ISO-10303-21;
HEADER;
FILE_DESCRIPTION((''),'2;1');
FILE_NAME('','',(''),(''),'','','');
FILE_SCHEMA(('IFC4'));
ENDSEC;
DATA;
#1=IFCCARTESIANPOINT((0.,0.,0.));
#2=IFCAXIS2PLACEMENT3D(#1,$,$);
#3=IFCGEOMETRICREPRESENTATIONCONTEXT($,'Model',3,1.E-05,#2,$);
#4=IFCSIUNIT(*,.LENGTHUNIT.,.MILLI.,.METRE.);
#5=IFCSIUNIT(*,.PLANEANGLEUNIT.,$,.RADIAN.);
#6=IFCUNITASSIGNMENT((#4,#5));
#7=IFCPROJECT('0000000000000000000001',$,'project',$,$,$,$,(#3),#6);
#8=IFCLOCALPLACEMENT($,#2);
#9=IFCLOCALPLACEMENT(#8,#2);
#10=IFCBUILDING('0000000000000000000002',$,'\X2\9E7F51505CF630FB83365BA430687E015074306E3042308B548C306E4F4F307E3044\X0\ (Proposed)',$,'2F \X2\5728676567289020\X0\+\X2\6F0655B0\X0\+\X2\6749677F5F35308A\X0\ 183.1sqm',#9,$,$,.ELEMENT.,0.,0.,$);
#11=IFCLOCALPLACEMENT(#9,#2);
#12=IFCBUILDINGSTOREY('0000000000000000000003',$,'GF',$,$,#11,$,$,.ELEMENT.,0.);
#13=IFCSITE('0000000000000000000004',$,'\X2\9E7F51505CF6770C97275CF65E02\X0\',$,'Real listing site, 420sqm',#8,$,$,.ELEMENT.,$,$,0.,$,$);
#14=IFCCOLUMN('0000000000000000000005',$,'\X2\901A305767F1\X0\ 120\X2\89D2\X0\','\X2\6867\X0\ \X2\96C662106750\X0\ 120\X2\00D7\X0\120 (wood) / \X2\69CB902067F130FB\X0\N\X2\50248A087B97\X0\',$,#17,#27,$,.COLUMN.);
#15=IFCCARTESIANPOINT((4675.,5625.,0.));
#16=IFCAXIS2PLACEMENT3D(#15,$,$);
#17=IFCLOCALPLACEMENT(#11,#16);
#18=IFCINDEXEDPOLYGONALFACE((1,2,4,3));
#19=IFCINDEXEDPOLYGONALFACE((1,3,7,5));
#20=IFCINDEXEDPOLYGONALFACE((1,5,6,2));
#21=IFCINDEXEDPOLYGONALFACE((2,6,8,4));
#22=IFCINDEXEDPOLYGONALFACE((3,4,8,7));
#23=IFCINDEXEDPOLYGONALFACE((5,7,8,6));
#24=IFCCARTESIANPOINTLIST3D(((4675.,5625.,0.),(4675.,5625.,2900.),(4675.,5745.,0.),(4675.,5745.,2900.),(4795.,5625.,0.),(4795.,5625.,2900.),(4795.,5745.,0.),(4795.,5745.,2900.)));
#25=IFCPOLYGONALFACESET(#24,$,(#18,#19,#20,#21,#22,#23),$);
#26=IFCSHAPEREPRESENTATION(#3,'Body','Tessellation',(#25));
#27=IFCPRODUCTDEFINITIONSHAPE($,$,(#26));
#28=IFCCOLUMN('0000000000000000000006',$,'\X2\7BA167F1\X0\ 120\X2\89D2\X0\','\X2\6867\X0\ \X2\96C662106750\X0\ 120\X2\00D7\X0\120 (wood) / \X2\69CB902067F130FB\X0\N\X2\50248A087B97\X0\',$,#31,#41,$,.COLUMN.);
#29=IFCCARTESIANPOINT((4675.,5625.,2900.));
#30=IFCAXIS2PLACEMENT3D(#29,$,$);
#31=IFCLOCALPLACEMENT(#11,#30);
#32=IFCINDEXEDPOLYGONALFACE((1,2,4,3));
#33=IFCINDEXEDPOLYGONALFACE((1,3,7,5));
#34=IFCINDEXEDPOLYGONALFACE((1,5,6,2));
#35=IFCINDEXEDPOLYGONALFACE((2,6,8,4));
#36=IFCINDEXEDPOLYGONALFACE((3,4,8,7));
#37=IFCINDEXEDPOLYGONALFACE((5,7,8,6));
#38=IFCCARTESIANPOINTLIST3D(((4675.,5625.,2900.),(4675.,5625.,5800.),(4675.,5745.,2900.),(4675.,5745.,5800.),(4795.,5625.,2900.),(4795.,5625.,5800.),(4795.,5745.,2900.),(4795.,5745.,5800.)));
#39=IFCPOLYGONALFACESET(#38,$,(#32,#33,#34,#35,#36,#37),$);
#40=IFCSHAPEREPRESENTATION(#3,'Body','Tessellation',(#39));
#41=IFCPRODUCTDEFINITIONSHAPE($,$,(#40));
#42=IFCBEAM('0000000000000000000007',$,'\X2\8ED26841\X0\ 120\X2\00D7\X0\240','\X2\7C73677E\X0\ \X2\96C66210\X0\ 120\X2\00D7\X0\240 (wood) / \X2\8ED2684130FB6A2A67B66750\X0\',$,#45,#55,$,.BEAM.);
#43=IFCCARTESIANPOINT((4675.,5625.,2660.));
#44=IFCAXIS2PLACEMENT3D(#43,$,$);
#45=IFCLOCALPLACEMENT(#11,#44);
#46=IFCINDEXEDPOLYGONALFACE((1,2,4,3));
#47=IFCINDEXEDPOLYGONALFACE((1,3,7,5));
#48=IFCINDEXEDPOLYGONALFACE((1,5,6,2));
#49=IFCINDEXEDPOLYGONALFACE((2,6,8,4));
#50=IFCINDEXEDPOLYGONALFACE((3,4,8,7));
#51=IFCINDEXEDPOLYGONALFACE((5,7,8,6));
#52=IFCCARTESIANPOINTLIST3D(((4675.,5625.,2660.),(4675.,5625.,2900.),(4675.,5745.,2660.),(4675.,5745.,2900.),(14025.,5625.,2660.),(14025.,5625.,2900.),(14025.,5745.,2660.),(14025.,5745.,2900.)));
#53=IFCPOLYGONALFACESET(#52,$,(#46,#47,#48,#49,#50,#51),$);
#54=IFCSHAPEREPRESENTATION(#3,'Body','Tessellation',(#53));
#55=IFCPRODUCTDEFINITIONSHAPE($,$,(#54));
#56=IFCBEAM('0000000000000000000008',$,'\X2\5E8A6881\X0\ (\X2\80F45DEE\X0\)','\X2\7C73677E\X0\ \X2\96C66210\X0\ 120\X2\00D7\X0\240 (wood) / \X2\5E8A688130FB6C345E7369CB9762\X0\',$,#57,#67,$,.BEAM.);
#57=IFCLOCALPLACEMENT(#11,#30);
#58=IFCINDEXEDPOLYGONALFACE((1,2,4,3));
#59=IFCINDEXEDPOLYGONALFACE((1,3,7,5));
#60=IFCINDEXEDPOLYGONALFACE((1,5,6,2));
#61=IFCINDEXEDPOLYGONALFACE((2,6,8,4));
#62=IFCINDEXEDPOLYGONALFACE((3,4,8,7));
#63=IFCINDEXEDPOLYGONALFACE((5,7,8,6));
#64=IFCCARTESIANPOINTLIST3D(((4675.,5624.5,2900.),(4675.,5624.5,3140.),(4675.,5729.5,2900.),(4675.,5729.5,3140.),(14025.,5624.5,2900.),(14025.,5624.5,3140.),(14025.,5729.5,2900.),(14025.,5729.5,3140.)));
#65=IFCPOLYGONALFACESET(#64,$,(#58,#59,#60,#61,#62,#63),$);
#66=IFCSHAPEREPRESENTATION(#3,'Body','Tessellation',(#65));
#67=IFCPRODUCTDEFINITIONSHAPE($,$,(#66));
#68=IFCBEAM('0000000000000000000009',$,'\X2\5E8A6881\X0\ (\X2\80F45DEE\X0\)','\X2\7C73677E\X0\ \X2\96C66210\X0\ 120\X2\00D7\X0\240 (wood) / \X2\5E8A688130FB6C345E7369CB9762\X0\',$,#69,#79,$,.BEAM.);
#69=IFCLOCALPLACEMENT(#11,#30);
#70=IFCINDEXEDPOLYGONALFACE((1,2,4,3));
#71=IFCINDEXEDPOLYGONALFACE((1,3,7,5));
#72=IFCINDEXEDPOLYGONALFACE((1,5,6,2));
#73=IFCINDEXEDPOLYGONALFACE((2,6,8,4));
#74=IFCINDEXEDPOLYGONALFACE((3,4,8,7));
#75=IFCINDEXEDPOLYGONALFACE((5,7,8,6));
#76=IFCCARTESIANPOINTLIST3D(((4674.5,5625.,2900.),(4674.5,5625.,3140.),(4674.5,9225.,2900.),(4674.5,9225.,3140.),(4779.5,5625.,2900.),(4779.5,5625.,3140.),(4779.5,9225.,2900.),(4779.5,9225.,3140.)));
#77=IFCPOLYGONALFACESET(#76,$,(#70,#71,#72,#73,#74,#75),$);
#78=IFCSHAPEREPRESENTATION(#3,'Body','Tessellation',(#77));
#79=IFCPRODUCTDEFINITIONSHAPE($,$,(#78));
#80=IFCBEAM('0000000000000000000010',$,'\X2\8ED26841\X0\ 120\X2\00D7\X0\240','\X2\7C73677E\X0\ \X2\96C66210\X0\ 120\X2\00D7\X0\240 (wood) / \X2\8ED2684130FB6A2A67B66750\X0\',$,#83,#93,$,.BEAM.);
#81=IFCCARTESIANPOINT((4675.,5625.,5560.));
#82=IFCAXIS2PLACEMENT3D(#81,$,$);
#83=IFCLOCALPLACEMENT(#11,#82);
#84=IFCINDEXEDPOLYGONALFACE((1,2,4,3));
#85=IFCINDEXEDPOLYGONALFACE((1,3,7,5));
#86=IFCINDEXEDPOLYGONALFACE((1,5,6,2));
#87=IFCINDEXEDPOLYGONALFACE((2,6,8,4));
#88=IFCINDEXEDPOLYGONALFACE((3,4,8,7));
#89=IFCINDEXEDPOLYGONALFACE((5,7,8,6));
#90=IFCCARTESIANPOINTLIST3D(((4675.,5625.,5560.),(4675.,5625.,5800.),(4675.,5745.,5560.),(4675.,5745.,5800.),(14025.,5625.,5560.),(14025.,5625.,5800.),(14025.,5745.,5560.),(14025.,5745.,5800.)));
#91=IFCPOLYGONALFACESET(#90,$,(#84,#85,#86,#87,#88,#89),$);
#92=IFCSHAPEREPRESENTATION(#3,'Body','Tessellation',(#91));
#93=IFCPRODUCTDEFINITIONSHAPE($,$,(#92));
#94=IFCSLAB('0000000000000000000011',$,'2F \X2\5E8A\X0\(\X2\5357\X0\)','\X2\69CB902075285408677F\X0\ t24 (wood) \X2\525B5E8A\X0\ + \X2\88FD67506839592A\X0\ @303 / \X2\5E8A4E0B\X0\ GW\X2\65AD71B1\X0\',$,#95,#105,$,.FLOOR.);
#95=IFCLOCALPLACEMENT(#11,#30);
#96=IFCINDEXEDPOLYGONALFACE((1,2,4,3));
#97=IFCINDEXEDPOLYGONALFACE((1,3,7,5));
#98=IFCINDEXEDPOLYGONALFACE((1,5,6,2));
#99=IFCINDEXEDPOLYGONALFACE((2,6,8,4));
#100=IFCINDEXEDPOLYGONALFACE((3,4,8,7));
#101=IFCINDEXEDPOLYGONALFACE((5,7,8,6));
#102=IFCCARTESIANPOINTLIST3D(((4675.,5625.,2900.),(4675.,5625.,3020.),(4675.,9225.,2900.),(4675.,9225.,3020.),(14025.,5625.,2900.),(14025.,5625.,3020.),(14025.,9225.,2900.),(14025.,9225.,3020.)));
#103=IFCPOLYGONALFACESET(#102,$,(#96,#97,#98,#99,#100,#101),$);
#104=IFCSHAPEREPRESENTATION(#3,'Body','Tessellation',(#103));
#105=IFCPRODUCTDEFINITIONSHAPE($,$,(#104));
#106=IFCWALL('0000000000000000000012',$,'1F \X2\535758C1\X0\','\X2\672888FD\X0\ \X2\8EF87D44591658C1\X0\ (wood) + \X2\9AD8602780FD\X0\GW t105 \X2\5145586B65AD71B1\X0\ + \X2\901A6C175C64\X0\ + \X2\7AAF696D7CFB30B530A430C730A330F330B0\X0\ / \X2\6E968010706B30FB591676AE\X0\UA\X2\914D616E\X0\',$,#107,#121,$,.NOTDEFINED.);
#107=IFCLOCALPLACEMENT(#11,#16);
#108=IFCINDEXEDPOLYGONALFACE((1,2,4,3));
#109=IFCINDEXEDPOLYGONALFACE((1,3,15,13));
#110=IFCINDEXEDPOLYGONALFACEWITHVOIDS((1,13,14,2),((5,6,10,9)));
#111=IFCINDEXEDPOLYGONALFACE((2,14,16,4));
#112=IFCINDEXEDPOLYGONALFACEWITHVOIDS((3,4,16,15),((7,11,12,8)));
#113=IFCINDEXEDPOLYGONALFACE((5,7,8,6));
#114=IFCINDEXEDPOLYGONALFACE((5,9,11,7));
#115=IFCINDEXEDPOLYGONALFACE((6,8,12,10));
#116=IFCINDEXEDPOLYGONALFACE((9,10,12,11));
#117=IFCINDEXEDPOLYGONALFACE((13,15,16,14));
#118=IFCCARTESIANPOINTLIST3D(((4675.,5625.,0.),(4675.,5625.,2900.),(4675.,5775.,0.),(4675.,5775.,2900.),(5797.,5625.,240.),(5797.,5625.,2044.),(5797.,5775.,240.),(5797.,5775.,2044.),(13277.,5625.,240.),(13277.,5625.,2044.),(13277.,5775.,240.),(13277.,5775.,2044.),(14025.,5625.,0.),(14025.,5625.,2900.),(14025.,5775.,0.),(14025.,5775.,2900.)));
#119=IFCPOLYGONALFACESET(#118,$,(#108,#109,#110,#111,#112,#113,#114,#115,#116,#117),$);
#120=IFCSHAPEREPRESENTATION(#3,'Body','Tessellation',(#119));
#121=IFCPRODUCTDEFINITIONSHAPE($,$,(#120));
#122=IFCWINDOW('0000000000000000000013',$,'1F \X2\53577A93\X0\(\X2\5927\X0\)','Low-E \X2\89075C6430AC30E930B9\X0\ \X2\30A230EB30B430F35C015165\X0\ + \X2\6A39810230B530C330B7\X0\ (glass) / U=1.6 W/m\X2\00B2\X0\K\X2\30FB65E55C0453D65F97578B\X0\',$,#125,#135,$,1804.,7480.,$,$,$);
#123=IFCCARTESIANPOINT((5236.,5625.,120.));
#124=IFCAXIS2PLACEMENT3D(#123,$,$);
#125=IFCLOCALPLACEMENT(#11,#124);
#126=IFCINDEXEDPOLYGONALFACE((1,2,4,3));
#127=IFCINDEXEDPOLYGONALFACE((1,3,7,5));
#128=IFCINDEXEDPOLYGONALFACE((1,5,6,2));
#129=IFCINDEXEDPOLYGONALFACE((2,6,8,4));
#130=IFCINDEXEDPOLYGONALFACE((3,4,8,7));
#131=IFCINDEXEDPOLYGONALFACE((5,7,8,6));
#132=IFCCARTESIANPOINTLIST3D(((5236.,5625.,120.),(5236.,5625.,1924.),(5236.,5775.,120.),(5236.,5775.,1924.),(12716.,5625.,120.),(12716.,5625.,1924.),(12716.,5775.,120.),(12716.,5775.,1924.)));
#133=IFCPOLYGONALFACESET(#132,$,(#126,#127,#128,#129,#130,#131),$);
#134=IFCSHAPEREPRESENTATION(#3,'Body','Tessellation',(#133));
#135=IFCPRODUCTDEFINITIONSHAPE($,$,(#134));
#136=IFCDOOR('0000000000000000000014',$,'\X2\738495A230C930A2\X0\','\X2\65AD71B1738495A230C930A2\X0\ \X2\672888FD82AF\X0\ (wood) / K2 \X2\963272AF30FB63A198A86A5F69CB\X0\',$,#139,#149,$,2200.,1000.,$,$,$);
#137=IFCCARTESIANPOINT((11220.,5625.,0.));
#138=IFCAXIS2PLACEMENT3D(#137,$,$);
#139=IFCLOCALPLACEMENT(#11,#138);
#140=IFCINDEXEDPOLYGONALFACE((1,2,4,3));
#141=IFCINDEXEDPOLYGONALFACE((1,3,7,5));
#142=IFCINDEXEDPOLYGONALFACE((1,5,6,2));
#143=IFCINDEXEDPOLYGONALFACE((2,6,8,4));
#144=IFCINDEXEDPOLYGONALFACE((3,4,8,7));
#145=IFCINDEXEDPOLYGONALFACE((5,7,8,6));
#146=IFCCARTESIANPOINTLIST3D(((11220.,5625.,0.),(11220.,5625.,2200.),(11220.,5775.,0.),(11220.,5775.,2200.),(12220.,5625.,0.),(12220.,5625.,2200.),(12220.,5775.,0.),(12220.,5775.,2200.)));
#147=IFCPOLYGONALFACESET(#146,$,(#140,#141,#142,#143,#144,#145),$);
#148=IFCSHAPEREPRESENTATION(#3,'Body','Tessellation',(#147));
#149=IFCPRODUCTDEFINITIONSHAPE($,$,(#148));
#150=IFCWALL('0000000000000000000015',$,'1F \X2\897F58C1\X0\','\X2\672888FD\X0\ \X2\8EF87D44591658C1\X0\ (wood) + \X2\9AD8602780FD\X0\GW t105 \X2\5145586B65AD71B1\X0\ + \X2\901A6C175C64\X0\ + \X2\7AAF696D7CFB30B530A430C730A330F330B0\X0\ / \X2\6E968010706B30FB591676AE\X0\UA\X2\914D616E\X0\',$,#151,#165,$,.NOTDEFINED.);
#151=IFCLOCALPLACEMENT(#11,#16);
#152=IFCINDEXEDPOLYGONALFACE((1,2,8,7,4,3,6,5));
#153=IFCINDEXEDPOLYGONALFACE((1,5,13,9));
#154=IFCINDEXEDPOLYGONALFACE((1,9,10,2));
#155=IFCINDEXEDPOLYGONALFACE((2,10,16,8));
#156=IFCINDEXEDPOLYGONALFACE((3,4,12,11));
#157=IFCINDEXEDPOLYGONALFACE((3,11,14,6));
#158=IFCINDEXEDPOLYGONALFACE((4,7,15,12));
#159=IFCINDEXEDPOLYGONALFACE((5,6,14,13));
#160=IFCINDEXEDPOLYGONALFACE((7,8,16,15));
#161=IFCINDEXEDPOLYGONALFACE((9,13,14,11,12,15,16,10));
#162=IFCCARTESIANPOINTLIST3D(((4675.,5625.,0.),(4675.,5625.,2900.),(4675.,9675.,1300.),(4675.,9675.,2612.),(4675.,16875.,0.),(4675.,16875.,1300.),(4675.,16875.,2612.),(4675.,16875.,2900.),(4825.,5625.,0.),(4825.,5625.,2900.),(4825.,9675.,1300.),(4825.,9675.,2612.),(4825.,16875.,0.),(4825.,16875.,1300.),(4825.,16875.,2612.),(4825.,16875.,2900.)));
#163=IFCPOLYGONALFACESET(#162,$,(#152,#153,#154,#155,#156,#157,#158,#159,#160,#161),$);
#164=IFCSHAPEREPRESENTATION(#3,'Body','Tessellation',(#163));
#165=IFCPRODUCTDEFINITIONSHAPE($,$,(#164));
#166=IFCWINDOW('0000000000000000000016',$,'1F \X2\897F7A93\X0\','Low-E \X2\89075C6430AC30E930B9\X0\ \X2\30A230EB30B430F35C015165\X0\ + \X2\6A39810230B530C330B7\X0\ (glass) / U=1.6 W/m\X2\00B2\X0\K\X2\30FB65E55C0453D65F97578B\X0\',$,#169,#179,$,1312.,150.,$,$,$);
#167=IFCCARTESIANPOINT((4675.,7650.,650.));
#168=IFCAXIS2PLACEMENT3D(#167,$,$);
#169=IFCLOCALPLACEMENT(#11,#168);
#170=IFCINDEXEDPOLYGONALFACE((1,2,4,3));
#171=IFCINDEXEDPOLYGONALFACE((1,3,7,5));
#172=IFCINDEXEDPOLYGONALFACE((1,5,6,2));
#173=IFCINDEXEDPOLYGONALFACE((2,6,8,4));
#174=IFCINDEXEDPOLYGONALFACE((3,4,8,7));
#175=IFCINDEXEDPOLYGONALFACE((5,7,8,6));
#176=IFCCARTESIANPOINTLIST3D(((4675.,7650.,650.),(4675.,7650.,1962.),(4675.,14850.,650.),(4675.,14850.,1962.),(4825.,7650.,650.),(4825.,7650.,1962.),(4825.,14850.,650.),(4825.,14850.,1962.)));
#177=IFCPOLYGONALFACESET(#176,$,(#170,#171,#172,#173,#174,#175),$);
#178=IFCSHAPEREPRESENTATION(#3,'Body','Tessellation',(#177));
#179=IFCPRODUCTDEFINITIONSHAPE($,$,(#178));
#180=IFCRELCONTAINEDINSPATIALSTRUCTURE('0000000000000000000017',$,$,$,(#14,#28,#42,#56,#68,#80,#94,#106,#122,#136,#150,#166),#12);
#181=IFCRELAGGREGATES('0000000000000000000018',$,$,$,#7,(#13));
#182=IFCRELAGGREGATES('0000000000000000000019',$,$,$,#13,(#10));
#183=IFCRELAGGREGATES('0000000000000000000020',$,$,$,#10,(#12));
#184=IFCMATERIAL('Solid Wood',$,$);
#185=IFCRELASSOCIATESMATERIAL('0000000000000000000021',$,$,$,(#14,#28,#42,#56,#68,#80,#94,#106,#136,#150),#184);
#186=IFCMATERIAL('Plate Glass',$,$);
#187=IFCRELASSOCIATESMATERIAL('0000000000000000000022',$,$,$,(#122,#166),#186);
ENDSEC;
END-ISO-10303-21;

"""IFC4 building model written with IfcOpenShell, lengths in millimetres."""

from ifc_helpers import new_model, si_unit, frame, frame_2d, origin, place, context, project, spatial, rectangle, extrude, material, element, fill, save


model = new_model("IFC4")

# Units and contexts
model_context = context("Model", 3, precision=1e-05, world=origin())
ifc_project = project(units=[si_unit("LENGTHUNIT", "METRE", prefix="MILLI"), si_unit("PLANEANGLEUNIT", "RADIAN")], contexts=[model_context])

# Site, building, storey
site_placement = place(None, origin())
site = spatial("IfcSite", under=ifc_project, at=site_placement, Name="鹿児島県霧島市", ObjectType="Real listing site, 420sqm", CompositionType="ELEMENT", RefElevation=0.0)
building_placement = place(site_placement, origin())
building = spatial("IfcBuilding", under=site, at=building_placement, Name="鹿児島・茶室と縁側のある和の住まい (Proposed)", ObjectType="2F 在来木造+漆喰+杉板張り 183.1sqm", CompositionType="ELEMENT", ElevationOfRefHeight=0.0, ElevationOfTerrain=0.0)
storey_placement = place(building_placement, origin())
storey = spatial("IfcBuildingStorey", under=building, at=storey_placement, Name="GF", CompositionType="ELEMENT", Elevation=0.0)

# Columns
ifc_material_1 = material(Name="Solid Wood")
column_1_placement = place(storey_placement, frame((4675.0, 5625.0, 0.0)))
element("IfcColumn", 1, at=column_1_placement, inside=storey, material=ifc_material_1, Name="通し柱 120角", Description="桧 集成材 120×120 (wood) / 構造柱・N値計算", PredefinedType="COLUMN", context=model_context, shape_type="SweptSolid", body=[
    extrude(rectangle(XDim=120.0, YDim=120.0, at=frame_2d((60.0, 60.0))), frame((4675.0, 5625.0, 0.0)), (0.0, 0.0, 1.0), 2900.0),
])
column_2_placement = place(storey_placement, frame((4675.0, 5625.0, 2900.0)))
element("IfcColumn", 2, at=column_2_placement, inside=storey, material=ifc_material_1, Name="管柱 120角", Description="桧 集成材 120×120 (wood) / 構造柱・N値計算", PredefinedType="COLUMN", context=model_context, shape_type="SweptSolid", body=[
    extrude(rectangle(XDim=120.0, YDim=120.0, at=frame_2d((60.0, 60.0))), frame((4675.0, 5625.0, 2900.0)), (0.0, 0.0, 1.0), 2900.0),
])

# Beams
beam_1_placement = place(storey_placement, frame((4675.0, 5625.0, 2660.0)))
element("IfcBeam", 3, at=beam_1_placement, inside=storey, material=ifc_material_1, Name="軒桁 120×240", Description="米松 集成 120×240 (wood) / 軒桁・横架材", PredefinedType="BEAM", context=model_context, shape_type="SweptSolid", body=[
    extrude(rectangle(XDim=9350.0, YDim=120.0, at=frame_2d((4675.0, 60.0))), frame((4675.0, 5625.0, 2660.0)), (0.0, 0.0, 1.0), 240.0),
])
beam_2_placement = place(storey_placement, frame((4675.0, 5625.0, 2900.0)))
element("IfcBeam", 4, at=beam_2_placement, inside=storey, material=ifc_material_1, Name="床梁 (胴差)", Description="米松 集成 120×240 (wood) / 床梁・水平構面", PredefinedType="BEAM", context=model_context, shape_type="SweptSolid", body=[
    extrude(rectangle(XDim=9350.0, YDim=105.0, at=frame_2d((4675.0, 52.0))), frame((4675.0, 5625.0, 2900.0)), (0.0, 0.0, 1.0), 240.0),
])
beam_3_placement = place(storey_placement, frame((4675.0, 5625.0, 2900.0)))
element("IfcBeam", 5, at=beam_3_placement, inside=storey, material=ifc_material_1, Name="床梁 (胴差)", Description="米松 集成 120×240 (wood) / 床梁・水平構面", PredefinedType="BEAM", context=model_context, shape_type="SweptSolid", body=[
    extrude(rectangle(XDim=105.0, YDim=3600.0, at=frame_2d((52.0, 1800.0))), frame((4675.0, 5625.0, 2900.0)), (0.0, 0.0, 1.0), 240.0),
])
beam_4_placement = place(storey_placement, frame((4675.0, 5625.0, 5560.0)))
element("IfcBeam", 6, at=beam_4_placement, inside=storey, material=ifc_material_1, Name="軒桁 120×240", Description="米松 集成 120×240 (wood) / 軒桁・横架材", PredefinedType="BEAM", context=model_context, shape_type="SweptSolid", body=[
    extrude(rectangle(XDim=9350.0, YDim=120.0, at=frame_2d((4675.0, 60.0))), frame((4675.0, 5625.0, 5560.0)), (0.0, 0.0, 1.0), 240.0),
])

# Slab
slab_1_placement = place(storey_placement, frame((4675.0, 5625.0, 2900.0)))
element("IfcSlab", 7, at=slab_1_placement, inside=storey, material=ifc_material_1, Name="2F 床(南)", Description="構造用合板 t24 (wood) 剛床 + 製材根太 @303 / 床下 GW断熱", PredefinedType="FLOOR", context=model_context, shape_type="SweptSolid", body=[
    extrude(rectangle(XDim=9350.0, YDim=3600.0, at=frame_2d((4675.0, 1800.0))), frame((4675.0, 5625.0, 2900.0)), (0.0, 0.0, 1.0), 120.0),
])

# Wall, openings, window, door
wall_1_placement = place(storey_placement, frame((4675.0, 5625.0, 0.0)))
wall_1 = element("IfcWall", 8, at=wall_1_placement, inside=storey, material=ifc_material_1, Name="1F 南壁", Description="木製 軸組外壁 (wood) + 高性能GW t105 充填断熱 + 通気層 + 窯業系サイディング / 準耐火・外皮UA配慮", PredefinedType="NOTDEFINED", context=model_context, shape_type="SweptSolid", body=[
    extrude(rectangle(XDim=9350.0, YDim=150.0, at=frame_2d((4675.0, 75.0))), frame((4675.0, 5625.0, 0.0)), (0.0, 0.0, 1.0), 2900.0),
])
opening_1_placement = place(storey_placement, frame((5236.0, 5625.0, 120.0)))
opening_1 = element("IfcOpeningElement", 9, at=opening_1_placement, cuts=wall_1, PredefinedType="NOTDEFINED", context=model_context, shape_type="SweptSolid", body=[
    extrude(rectangle(XDim=7480.0, YDim=150.0, at=frame_2d((3740.0, 75.0))), frame((5236.0, 5625.0, 120.0)), (0.0, 0.0, 1.0), 1804.0),
])
opening_2_placement = place(storey_placement, frame((11220.0, 5625.0, 0.0)))
opening_2 = element("IfcOpeningElement", 10, at=opening_2_placement, cuts=wall_1, PredefinedType="NOTDEFINED", context=model_context, shape_type="SweptSolid", body=[
    extrude(rectangle(XDim=1000.0, YDim=150.0, at=frame_2d((500.0, 75.0))), frame((11220.0, 5625.0, 0.0)), (0.0, 0.0, 1.0), 2200.0),
])
ifc_material_2 = material(Name="Plate Glass")
window_1_placement = place(storey_placement, frame((5236.0, 5625.0, 120.0)))
window_1 = element("IfcWindow", 11, at=window_1_placement, inside=storey, material=ifc_material_2, Name="1F 南窓(大)", Description="Low-E 複層ガラス アルゴン封入 + 樹脂サッシ (glass) / U=1.6 W/m²K・日射取得型", OverallHeight=1804.0, OverallWidth=7480.0, context=model_context, shape_type="SweptSolid", body=[
    extrude(rectangle(XDim=7480.0, YDim=150.0, at=frame_2d((3740.0, 75.0))), frame((5236.0, 5625.0, 120.0)), (0.0, 0.0, 1.0), 1804.0),
])
fill(opening_1, window_1)
door_placement = place(storey_placement, frame((11220.0, 5625.0, 0.0)))
door = element("IfcDoor", 12, at=door_placement, inside=storey, material=ifc_material_1, Name="玄関ドア", Description="断熱玄関ドア 木製芯 (wood) / K2 防犯・採風機構", OverallHeight=2200.0, OverallWidth=1000.0, context=model_context, shape_type="SweptSolid", body=[
    extrude(rectangle(XDim=1000.0, YDim=150.0, at=frame_2d((500.0, 75.0))), frame((11220.0, 5625.0, 0.0)), (0.0, 0.0, 1.0), 2200.0),
])
fill(opening_2, door)

# Wall, opening, window
wall_2_placement = place(storey_placement, frame((4675.0, 5625.0, 0.0)))
wall_2 = element("IfcWall", 13, at=wall_2_placement, inside=storey, material=ifc_material_1, Name="1F 西壁", Description="木製 軸組外壁 (wood) + 高性能GW t105 充填断熱 + 通気層 + 窯業系サイディング / 準耐火・外皮UA配慮", PredefinedType="NOTDEFINED", context=model_context, shape_type="SweptSolid", body=[
    extrude(rectangle(XDim=150.0, YDim=11250.0, at=frame_2d((75.0, 5625.0))), frame((4675.0, 5625.0, 0.0)), (0.0, 0.0, 1.0), 2900.0),
])
opening_3_placement = place(storey_placement, frame((4675.0, 7650.0, 650.0)))
opening_3 = element("IfcOpeningElement", 14, at=opening_3_placement, cuts=wall_2, PredefinedType="NOTDEFINED", context=model_context, shape_type="SweptSolid", body=[
    extrude(rectangle(XDim=150.0, YDim=7200.0, at=frame_2d((75.0, 3600.0))), frame((4675.0, 7650.0, 650.0)), (0.0, 0.0, 1.0), 1312.0),
])
window_2_placement = place(storey_placement, frame((4675.0, 7650.0, 650.0)))
window_2 = element("IfcWindow", 15, at=window_2_placement, inside=storey, material=ifc_material_2, Name="1F 西窓", Description="Low-E 複層ガラス アルゴン封入 + 樹脂サッシ (glass) / U=1.6 W/m²K・日射取得型", OverallHeight=1312.0, OverallWidth=150.0, context=model_context, shape_type="SweptSolid", body=[
    extrude(rectangle(XDim=150.0, YDim=7200.0, at=frame_2d((75.0, 3600.0))), frame((4675.0, 7650.0, 650.0)), (0.0, 0.0, 1.0), 1312.0),
])
fill(opening_3, window_2)

save(model, "model.ifc")
